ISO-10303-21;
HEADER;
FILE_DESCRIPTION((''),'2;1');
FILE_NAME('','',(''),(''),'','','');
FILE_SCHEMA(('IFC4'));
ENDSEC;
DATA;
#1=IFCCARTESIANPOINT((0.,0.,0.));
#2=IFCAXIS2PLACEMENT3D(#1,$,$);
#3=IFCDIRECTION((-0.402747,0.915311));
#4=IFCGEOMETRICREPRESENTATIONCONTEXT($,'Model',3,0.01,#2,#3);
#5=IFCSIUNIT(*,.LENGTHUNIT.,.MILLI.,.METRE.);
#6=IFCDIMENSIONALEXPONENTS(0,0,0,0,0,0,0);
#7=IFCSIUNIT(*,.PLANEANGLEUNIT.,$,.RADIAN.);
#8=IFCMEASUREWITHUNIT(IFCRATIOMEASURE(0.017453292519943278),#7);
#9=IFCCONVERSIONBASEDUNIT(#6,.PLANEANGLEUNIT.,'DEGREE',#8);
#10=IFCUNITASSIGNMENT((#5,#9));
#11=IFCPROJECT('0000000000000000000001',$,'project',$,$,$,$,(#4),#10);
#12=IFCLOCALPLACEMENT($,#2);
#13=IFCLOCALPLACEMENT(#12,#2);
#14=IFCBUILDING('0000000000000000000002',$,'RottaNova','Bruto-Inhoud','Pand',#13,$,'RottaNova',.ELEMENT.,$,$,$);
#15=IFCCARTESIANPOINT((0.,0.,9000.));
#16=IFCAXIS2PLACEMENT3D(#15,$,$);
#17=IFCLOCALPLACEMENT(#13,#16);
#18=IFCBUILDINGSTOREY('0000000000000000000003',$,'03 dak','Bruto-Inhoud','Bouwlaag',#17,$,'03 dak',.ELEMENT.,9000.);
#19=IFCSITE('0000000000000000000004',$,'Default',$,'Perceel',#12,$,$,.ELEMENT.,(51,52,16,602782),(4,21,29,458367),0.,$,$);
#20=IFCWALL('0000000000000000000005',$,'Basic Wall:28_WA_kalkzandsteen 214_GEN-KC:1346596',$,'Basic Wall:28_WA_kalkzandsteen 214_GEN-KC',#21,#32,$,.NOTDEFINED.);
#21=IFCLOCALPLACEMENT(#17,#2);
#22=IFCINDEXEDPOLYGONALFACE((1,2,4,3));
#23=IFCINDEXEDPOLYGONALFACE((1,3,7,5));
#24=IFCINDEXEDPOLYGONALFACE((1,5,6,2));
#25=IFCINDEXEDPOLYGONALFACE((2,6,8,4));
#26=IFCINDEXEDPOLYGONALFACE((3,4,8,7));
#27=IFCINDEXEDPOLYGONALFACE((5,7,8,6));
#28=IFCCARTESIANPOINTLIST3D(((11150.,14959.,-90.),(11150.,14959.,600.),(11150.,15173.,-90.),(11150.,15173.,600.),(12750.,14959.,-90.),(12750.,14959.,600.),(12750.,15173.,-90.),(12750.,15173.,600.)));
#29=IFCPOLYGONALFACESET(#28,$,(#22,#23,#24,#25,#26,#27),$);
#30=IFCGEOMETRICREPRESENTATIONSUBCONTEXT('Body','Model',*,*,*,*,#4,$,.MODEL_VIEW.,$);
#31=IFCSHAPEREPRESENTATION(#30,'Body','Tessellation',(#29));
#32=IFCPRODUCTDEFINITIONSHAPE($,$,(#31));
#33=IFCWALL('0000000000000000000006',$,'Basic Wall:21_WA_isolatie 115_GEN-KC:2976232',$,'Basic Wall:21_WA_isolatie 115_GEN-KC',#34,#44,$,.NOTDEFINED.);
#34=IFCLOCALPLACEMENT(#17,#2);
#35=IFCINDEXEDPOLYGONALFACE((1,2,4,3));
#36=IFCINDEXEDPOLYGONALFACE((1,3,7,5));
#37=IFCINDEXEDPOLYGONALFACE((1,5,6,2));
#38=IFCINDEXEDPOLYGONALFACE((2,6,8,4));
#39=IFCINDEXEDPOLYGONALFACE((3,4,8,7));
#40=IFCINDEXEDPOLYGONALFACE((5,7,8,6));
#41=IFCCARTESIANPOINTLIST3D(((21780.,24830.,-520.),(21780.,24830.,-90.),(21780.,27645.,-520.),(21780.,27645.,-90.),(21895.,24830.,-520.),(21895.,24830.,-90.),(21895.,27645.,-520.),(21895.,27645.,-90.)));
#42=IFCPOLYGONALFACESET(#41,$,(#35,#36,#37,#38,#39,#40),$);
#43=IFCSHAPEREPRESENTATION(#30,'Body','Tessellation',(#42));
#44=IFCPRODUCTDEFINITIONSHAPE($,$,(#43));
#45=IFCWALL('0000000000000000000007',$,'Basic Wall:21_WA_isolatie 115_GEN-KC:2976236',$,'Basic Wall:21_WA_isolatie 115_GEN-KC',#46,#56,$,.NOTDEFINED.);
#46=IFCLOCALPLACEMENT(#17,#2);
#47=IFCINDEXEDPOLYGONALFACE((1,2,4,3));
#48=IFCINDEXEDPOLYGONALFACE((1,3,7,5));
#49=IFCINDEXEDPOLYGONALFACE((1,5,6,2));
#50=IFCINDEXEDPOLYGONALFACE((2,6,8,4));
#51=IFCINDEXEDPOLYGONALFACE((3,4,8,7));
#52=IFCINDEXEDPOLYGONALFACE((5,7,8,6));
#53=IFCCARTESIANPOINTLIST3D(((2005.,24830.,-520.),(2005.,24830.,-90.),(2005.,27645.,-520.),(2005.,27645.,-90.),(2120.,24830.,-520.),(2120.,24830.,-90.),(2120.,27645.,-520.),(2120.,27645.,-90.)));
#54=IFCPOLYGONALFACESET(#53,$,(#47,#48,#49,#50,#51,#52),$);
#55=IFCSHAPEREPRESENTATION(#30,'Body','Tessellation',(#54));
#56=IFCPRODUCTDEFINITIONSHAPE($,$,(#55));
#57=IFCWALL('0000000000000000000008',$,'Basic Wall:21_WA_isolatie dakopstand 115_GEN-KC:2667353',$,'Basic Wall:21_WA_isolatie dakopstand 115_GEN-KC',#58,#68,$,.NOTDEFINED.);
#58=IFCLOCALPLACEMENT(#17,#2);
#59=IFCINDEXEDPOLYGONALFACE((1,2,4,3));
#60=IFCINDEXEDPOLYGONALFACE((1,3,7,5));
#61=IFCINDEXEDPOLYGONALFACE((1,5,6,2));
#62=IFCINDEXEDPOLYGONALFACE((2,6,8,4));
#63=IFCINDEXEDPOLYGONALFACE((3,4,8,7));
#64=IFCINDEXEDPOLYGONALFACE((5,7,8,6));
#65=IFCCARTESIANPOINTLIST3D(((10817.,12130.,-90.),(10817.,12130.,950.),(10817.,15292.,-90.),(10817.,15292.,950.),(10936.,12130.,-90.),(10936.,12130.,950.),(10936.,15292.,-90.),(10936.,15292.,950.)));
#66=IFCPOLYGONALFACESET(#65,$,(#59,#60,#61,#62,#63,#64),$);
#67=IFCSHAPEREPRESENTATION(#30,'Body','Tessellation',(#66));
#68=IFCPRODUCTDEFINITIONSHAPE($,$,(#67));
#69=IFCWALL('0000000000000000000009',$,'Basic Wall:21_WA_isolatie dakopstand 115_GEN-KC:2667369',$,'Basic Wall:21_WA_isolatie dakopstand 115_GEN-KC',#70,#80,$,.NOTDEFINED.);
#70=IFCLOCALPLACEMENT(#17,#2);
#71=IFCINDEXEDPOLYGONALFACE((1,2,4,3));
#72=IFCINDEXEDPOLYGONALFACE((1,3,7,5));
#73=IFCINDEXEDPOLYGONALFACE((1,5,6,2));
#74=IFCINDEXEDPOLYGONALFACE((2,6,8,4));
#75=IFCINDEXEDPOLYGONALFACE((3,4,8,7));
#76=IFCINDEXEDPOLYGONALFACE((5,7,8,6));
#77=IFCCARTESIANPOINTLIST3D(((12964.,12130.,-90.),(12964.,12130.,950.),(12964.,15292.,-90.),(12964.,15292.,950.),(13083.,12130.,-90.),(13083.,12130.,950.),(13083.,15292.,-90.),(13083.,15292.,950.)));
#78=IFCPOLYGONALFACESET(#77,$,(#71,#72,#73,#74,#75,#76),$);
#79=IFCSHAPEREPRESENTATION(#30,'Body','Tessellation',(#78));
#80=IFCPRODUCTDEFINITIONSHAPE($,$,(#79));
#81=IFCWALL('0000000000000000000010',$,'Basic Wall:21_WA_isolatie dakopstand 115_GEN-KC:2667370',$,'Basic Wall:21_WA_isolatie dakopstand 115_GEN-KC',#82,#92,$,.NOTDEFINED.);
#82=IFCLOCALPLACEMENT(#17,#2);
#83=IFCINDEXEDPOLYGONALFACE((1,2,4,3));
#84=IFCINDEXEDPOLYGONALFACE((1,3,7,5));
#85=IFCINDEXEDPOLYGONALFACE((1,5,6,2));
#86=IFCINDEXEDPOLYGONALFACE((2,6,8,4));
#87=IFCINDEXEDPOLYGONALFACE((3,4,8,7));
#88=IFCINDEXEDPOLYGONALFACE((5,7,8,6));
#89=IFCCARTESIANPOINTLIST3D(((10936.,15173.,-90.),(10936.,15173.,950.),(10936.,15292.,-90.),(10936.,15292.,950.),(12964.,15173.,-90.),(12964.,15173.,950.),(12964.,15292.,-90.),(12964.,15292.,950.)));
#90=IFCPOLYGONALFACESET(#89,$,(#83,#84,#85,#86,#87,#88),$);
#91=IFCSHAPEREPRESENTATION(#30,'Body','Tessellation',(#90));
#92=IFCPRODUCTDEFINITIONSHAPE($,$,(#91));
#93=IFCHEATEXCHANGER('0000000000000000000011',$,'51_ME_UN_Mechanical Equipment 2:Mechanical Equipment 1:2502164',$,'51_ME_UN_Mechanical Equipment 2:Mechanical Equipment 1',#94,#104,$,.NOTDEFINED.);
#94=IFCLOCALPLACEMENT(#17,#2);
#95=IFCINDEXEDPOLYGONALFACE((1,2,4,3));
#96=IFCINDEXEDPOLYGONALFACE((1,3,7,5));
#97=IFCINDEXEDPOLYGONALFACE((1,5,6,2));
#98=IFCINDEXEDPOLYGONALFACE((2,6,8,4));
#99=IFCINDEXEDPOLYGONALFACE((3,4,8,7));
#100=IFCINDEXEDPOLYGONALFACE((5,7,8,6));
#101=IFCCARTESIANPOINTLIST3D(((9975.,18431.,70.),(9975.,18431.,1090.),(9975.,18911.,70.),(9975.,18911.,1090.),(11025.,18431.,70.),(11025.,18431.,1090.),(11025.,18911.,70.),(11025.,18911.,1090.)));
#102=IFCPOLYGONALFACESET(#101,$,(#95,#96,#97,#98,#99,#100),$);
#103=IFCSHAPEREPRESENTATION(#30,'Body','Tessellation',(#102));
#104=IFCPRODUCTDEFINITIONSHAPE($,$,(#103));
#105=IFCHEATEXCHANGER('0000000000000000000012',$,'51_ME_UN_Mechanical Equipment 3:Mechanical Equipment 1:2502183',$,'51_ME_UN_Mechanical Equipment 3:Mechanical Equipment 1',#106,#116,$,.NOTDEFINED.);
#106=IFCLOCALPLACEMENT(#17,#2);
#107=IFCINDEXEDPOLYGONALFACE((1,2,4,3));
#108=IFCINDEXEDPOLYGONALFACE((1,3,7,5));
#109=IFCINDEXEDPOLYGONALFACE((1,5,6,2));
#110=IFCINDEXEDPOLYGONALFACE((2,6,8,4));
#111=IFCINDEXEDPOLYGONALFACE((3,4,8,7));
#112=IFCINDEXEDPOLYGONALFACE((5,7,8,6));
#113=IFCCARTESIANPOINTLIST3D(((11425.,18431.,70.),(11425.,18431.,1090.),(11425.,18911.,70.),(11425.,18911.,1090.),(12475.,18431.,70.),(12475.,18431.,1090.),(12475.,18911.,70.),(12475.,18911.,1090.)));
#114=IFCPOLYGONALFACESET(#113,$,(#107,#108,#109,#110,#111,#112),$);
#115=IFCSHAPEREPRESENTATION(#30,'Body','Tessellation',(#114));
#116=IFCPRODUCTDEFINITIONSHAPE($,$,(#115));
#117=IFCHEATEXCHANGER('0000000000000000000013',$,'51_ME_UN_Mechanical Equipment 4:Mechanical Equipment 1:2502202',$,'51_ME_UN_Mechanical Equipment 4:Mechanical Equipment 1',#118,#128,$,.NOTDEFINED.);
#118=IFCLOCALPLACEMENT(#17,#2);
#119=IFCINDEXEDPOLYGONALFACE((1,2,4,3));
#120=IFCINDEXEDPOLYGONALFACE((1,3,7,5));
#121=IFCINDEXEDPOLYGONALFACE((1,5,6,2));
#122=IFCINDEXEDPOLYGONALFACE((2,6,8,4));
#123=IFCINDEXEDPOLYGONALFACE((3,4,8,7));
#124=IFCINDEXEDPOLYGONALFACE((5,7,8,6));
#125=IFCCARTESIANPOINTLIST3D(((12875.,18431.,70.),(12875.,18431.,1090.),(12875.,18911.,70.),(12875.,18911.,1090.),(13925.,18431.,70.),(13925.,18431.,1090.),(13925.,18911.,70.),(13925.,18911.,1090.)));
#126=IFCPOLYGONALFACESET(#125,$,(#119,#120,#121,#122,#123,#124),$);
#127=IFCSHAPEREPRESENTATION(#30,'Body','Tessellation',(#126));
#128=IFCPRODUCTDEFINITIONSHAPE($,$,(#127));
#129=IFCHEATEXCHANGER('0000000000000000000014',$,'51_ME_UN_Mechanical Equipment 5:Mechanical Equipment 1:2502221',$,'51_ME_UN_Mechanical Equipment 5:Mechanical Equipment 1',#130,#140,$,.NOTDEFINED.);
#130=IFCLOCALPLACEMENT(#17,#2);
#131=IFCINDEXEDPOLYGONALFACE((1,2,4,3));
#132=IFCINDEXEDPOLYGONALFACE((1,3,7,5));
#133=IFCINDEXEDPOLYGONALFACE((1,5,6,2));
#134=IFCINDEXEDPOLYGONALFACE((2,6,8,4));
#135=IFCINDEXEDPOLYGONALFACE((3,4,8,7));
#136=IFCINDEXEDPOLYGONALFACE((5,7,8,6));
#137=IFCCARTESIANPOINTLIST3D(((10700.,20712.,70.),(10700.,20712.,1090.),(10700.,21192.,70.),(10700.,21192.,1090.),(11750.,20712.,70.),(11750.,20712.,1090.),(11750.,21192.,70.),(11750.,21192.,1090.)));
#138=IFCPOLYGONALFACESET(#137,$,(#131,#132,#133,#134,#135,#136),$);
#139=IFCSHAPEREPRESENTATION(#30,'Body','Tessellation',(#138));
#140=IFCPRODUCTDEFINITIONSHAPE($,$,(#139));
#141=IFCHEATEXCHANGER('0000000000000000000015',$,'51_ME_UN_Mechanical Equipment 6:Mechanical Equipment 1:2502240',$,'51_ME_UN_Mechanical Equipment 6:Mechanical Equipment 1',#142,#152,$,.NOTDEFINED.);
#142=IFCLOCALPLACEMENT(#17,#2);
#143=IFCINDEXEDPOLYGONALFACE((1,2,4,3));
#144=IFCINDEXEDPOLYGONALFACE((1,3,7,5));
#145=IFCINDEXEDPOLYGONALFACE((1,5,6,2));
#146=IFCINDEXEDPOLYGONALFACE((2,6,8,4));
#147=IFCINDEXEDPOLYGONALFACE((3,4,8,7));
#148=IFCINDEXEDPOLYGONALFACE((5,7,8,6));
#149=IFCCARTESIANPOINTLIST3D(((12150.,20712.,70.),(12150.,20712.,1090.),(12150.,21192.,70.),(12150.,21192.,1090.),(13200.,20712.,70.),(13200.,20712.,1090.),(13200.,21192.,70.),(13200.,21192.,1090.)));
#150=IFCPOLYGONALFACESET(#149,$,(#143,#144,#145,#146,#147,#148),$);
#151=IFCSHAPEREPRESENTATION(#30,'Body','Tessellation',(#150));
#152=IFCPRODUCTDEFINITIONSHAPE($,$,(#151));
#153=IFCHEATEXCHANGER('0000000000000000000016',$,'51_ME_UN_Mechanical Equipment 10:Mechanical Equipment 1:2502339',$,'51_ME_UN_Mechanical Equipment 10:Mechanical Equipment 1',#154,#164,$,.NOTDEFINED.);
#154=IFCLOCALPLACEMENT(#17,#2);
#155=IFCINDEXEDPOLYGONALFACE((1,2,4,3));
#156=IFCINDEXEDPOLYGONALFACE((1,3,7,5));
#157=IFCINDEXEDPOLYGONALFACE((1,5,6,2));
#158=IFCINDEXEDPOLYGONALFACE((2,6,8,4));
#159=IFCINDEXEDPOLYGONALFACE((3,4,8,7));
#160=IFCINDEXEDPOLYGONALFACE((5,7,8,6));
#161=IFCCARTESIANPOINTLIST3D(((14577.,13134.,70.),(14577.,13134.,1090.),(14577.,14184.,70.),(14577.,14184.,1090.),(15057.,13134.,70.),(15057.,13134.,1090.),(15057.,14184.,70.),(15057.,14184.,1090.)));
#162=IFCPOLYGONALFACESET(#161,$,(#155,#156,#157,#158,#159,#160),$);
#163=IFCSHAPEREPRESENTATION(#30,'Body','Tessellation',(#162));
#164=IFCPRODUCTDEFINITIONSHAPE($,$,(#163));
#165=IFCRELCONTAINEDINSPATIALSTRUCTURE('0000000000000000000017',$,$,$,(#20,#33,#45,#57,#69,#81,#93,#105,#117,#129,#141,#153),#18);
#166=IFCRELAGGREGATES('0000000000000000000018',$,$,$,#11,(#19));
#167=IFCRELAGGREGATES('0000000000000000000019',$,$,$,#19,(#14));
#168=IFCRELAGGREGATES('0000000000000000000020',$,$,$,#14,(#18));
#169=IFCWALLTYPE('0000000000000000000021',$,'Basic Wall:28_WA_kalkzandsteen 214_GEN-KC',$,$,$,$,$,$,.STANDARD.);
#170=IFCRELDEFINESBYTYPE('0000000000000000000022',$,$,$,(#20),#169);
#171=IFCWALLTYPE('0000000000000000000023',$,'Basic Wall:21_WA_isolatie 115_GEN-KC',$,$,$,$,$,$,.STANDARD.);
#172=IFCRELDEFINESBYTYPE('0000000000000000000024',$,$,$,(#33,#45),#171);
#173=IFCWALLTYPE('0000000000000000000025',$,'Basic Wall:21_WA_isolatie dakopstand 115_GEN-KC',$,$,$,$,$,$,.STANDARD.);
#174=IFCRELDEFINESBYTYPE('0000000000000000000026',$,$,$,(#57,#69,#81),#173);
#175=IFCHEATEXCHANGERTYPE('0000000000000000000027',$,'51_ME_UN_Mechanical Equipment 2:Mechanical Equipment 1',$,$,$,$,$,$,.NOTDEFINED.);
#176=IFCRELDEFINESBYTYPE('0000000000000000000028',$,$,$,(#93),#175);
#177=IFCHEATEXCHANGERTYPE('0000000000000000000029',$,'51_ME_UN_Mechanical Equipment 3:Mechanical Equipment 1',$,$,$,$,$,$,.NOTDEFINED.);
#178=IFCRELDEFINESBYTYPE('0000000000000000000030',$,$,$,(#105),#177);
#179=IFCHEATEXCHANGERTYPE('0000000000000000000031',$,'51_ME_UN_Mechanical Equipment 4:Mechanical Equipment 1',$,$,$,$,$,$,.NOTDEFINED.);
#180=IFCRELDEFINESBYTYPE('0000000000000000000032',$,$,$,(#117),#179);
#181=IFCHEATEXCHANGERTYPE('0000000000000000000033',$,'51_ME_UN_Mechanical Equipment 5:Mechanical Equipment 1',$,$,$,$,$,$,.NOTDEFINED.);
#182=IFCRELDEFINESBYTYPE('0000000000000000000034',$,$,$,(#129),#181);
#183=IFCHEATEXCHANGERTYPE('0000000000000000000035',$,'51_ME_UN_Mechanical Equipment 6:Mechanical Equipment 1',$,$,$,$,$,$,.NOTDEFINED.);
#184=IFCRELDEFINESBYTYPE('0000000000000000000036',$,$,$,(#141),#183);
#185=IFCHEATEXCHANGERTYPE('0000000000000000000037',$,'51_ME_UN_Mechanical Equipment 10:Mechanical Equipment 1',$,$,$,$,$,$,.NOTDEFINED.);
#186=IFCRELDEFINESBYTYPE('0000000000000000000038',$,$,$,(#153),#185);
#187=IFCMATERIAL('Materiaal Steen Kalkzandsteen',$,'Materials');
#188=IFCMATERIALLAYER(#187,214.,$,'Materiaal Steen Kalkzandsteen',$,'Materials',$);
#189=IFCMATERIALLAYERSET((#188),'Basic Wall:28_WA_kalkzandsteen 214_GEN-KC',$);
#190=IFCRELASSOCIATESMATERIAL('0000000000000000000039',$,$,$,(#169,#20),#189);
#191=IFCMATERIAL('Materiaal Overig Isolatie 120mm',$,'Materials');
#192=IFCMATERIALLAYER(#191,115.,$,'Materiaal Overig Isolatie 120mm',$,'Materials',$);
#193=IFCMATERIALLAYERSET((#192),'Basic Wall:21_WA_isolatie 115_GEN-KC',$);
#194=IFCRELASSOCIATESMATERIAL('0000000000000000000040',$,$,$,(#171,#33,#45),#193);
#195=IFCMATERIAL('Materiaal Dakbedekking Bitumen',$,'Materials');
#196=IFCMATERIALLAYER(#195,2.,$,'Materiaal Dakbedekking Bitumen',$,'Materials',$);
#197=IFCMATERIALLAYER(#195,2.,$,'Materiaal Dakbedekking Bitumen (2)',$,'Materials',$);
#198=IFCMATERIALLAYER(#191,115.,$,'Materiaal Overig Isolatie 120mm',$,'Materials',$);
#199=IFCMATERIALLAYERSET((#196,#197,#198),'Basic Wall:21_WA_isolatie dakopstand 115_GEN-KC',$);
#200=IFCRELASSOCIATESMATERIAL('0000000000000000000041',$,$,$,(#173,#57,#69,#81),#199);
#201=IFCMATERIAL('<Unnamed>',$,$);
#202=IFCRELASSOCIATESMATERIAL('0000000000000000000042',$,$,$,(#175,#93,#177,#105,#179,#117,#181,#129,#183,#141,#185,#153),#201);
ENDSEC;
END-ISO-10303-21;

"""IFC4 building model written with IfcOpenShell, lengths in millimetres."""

from ifc_helpers import new_model, entity, si_unit, converted_unit, direction, frame, frame_2d, origin, place, context, subcontext, project, spatial, rectangle, extrude, source, transform, mapped, material, layer, layer_set, type_object, type_shapes, element, save


model = new_model("IFC4")

# Units and contexts
model_context = context("Model", 3, precision=0.01, world=origin(), true_north=direction((-0.402747, 0.915311)))
body_context = subcontext(model_context, "Body", "Model", "MODEL_VIEW")
ifc_project = project(units=[si_unit("LENGTHUNIT", "METRE", prefix="MILLI"), converted_unit("PLANEANGLEUNIT", "DEGREE", entity("IfcRatioMeasure", 0.017453292519943278), si_unit("PLANEANGLEUNIT", "RADIAN"), dimensions=[0, 0, 0, 0, 0, 0, 0])], contexts=[model_context])

# Site, building, storey
site_placement = place(None, origin())
site = spatial("IfcSite", under=ifc_project, at=site_placement, Name="Default", ObjectType="Perceel", CompositionType="ELEMENT", RefLatitude=(51, 52, 16, 602782), RefLongitude=(4, 21, 29, 458367), RefElevation=0.0)
building_placement = place(site_placement, origin())
building = spatial("IfcBuilding", under=site, at=building_placement, Name="RottaNova", Description="Bruto-Inhoud", ObjectType="Pand", LongName="RottaNova", CompositionType="ELEMENT")
storey_placement = place(building_placement, frame((0.0, 0.0, 9000.0)))
storey = spatial("IfcBuildingStorey", under=building, at=storey_placement, Name="03 dak", Description="Bruto-Inhoud", ObjectType="Bouwlaag", LongName="03 dak", CompositionType="ELEMENT", Elevation=9000.0)

# Wall
ifc_material_1 = material(Name="Materiaal Steen Kalkzandsteen", Category="Materials")
ifc_layer_1 = layer(ifc_material_1, 214.0, Name="Materiaal Steen Kalkzandsteen", Category="Materials")
ifc_layer_set_1 = layer_set([ifc_layer_1], Name="Basic Wall:28_WA_kalkzandsteen 214_GEN-KC")
wall_type_1 = type_object("IfcWallType", Name="Basic Wall:28_WA_kalkzandsteen 214_GEN-KC", PredefinedType="STANDARD", material=ifc_layer_set_1)
wall_1_placement = place(storey_placement, frame((11150.0, 15066.0, -90.0)))
element("IfcWall", 1, at=wall_1_placement, inside=storey, type_object=wall_type_1, material=ifc_layer_set_1, Name="Basic Wall:28_WA_kalkzandsteen 214_GEN-KC:1346596", ObjectType="Basic Wall:28_WA_kalkzandsteen 214_GEN-KC", PredefinedType="NOTDEFINED", context=body_context, shape_type="SweptSolid", body=[
    extrude(rectangle(XDim=1600.0, YDim=214.0, at=frame_2d((800.0, 0.0), x_axis=(-1.0, 0.0))), origin(), (0.0, 0.0, 1.0), 690.0),
])

# Shared definitions
ifc_material_2 = material(Name="Materiaal Overig Isolatie 120mm", Category="Materials")
ifc_layer_2 = layer(ifc_material_2, 115.0, Name="Materiaal Overig Isolatie 120mm", Category="Materials")
ifc_layer_set_2 = layer_set([ifc_layer_2], Name="Basic Wall:21_WA_isolatie 115_GEN-KC")
wall_type_2 = type_object("IfcWallType", Name="Basic Wall:21_WA_isolatie 115_GEN-KC", PredefinedType="STANDARD", material=ifc_layer_set_2)

# Wall
wall_2_placement = place(storey_placement, frame((21837.5, 24830.0, -520.0), z_axis=(0.0, 0.0, 1.0), x_axis=(0.0, 1.0, 0.0)))
element("IfcWall", 2, at=wall_2_placement, inside=storey, type_object=wall_type_2, material=ifc_layer_set_2, Name="Basic Wall:21_WA_isolatie 115_GEN-KC:2976232", ObjectType="Basic Wall:21_WA_isolatie 115_GEN-KC", PredefinedType="NOTDEFINED", context=body_context, shape_type="SweptSolid", body=[
    extrude(rectangle(XDim=2815.0, YDim=115.0, at=frame_2d((1407.5, 0.0), x_axis=(-1.0, 0.0))), origin(), (0.0, 0.0, 1.0), 430.0),
])

# Walls
wall_3_placement = place(storey_placement, frame((2062.5, 24830.0, -520.0), z_axis=(0.0, 0.0, 1.0), x_axis=(0.0, 1.0, 0.0)))
element("IfcWall", 3, at=wall_3_placement, inside=storey, type_object=wall_type_2, material=ifc_layer_set_2, Name="Basic Wall:21_WA_isolatie 115_GEN-KC:2976236", ObjectType="Basic Wall:21_WA_isolatie 115_GEN-KC", PredefinedType="NOTDEFINED", context=body_context, shape_type="SweptSolid", body=[
    extrude(rectangle(XDim=2815.0, YDim=115.0, at=frame_2d((1407.5, 0.0), x_axis=(-1.0, 0.0))), origin(), (0.0, 0.0, 1.0), 430.0),
])
ifc_material_3 = material(Name="Materiaal Dakbedekking Bitumen", Category="Materials")
ifc_layer_3 = layer(ifc_material_3, 2.0, Name="Materiaal Dakbedekking Bitumen", Category="Materials")
ifc_layer_4 = layer(ifc_material_3, 2.0, Name="Materiaal Dakbedekking Bitumen (2)", Category="Materials")
ifc_layer_5 = layer(ifc_material_2, 115.0, Name="Materiaal Overig Isolatie 120mm", Category="Materials")
ifc_layer_set_3 = layer_set([ifc_layer_3, ifc_layer_4, ifc_layer_5], Name="Basic Wall:21_WA_isolatie dakopstand 115_GEN-KC")
wall_type_3 = type_object("IfcWallType", Name="Basic Wall:21_WA_isolatie dakopstand 115_GEN-KC", PredefinedType="STANDARD", material=ifc_layer_set_3)
wall_4_placement = place(storey_placement, frame((10876.5, 15292.0, -90.0), z_axis=(0.0, 0.0, 1.0), x_axis=(0.0, -1.0, 0.0)))
element("IfcWall", 4, at=wall_4_placement, inside=storey, type_object=wall_type_3, material=ifc_layer_set_3, Name="Basic Wall:21_WA_isolatie dakopstand 115_GEN-KC:2667353", ObjectType="Basic Wall:21_WA_isolatie dakopstand 115_GEN-KC", PredefinedType="NOTDEFINED", context=body_context, shape_type="SweptSolid", body=[
    extrude(rectangle(XDim=3162.0, YDim=119.0, at=frame_2d((1581.0, 0.0), x_axis=(-1.0, 0.0))), origin(), (0.0, 0.0, 1.0), 1040.0),
])
wall_5_placement = place(storey_placement, frame((13023.5, 15292.0, -90.0), z_axis=(0.0, 0.0, 1.0), x_axis=(0.0, -1.0, 0.0)))
element("IfcWall", 5, at=wall_5_placement, inside=storey, type_object=wall_type_3, material=ifc_layer_set_3, Name="Basic Wall:21_WA_isolatie dakopstand 115_GEN-KC:2667369", ObjectType="Basic Wall:21_WA_isolatie dakopstand 115_GEN-KC", PredefinedType="NOTDEFINED", context=body_context, shape_type="SweptSolid", body=[
    extrude(rectangle(XDim=3162.0, YDim=119.0, at=frame_2d((1581.0, 0.0), x_axis=(-1.0, 0.0))), origin(), (0.0, 0.0, 1.0), 1040.0),
])
wall_6_placement = place(storey_placement, frame((10936.0, 15232.5, -90.0)))
element("IfcWall", 6, at=wall_6_placement, inside=storey, type_object=wall_type_3, material=ifc_layer_set_3, Name="Basic Wall:21_WA_isolatie dakopstand 115_GEN-KC:2667370", ObjectType="Basic Wall:21_WA_isolatie dakopstand 115_GEN-KC", PredefinedType="NOTDEFINED", context=body_context, shape_type="SweptSolid", body=[
    extrude(rectangle(XDim=2028.0, YDim=119.0, at=frame_2d((1014.0, 0.0), x_axis=(-1.0, 0.0))), origin(), (0.0, 0.0, 1.0), 1040.0),
])

# Heat exchangers
ifc_material_4 = material(Name="<Unnamed>")
heat_exchanger_type_1 = type_object("IfcHeatExchangerType", Name="51_ME_UN_Mechanical Equipment 2:Mechanical Equipment 1", PredefinedType="NOTDEFINED", material=ifc_material_4)
shared_shape_1 = source(origin(), body_context, "Body", "SweptSolid", [
    extrude(rectangle(XDim=1050.0, YDim=480.0, at=frame_2d((0.0, 0.0), x_axis=(1.0, 0.0))), frame((525.0, 240.0, 0.0), z_axis=(0.0, 0.0, 1.0), x_axis=(-1.0, 0.0, 0.0)), (0.0, 0.0, 1.0), 1020.0),
])
type_shapes(heat_exchanger_type_1, [shared_shape_1])
heat_exchanger_1_placement = place(storey_placement, frame((9975.0, 18431.0, 70.0)))
element("IfcHeatExchanger", 7, at=heat_exchanger_1_placement, inside=storey, type_object=heat_exchanger_type_1, material=ifc_material_4, Name="51_ME_UN_Mechanical Equipment 2:Mechanical Equipment 1:2502164", ObjectType="51_ME_UN_Mechanical Equipment 2:Mechanical Equipment 1", PredefinedType="NOTDEFINED", context=body_context, shape_type="MappedRepresentation", body=[
    mapped(shared_shape_1, transform((0.0, 0.0, 0.0), scale=1.0)),
])
heat_exchanger_type_2 = type_object("IfcHeatExchangerType", Name="51_ME_UN_Mechanical Equipment 3:Mechanical Equipment 1", PredefinedType="NOTDEFINED", material=ifc_material_4)
shared_shape_2 = source(origin(), body_context, "Body", "SweptSolid", [
    extrude(rectangle(XDim=1050.0, YDim=480.0, at=frame_2d((0.0, 0.0), x_axis=(1.0, 0.0))), frame((525.0, 240.0, 0.0), z_axis=(0.0, 0.0, 1.0), x_axis=(-1.0, 0.0, 0.0)), (0.0, 0.0, 1.0), 1020.0),
])
type_shapes(heat_exchanger_type_2, [shared_shape_2])
heat_exchanger_2_placement = place(storey_placement, frame((11425.0, 18431.0, 70.0)))
element("IfcHeatExchanger", 8, at=heat_exchanger_2_placement, inside=storey, type_object=heat_exchanger_type_2, material=ifc_material_4, Name="51_ME_UN_Mechanical Equipment 3:Mechanical Equipment 1:2502183", ObjectType="51_ME_UN_Mechanical Equipment 3:Mechanical Equipment 1", PredefinedType="NOTDEFINED", context=body_context, shape_type="MappedRepresentation", body=[
    mapped(shared_shape_2, transform((0.0, 0.0, 0.0), scale=1.0)),
])
heat_exchanger_type_3 = type_object("IfcHeatExchangerType", Name="51_ME_UN_Mechanical Equipment 4:Mechanical Equipment 1", PredefinedType="NOTDEFINED", material=ifc_material_4)
shared_shape_3 = source(origin(), body_context, "Body", "SweptSolid", [
    extrude(rectangle(XDim=1050.0, YDim=480.0, at=frame_2d((0.0, 0.0), x_axis=(1.0, 0.0))), frame((525.0, 240.0, 0.0), z_axis=(0.0, 0.0, 1.0), x_axis=(-1.0, 0.0, 0.0)), (0.0, 0.0, 1.0), 1020.0),
])
type_shapes(heat_exchanger_type_3, [shared_shape_3])
heat_exchanger_3_placement = place(storey_placement, frame((12875.0, 18431.0, 70.0)))
element("IfcHeatExchanger", 9, at=heat_exchanger_3_placement, inside=storey, type_object=heat_exchanger_type_3, material=ifc_material_4, Name="51_ME_UN_Mechanical Equipment 4:Mechanical Equipment 1:2502202", ObjectType="51_ME_UN_Mechanical Equipment 4:Mechanical Equipment 1", PredefinedType="NOTDEFINED", context=body_context, shape_type="MappedRepresentation", body=[
    mapped(shared_shape_3, transform((0.0, 0.0, 0.0), scale=1.0)),
])
heat_exchanger_type_4 = type_object("IfcHeatExchangerType", Name="51_ME_UN_Mechanical Equipment 5:Mechanical Equipment 1", PredefinedType="NOTDEFINED", material=ifc_material_4)
shared_shape_4 = source(origin(), body_context, "Body", "SweptSolid", [
    extrude(rectangle(XDim=1050.0, YDim=480.0, at=frame_2d((0.0, 0.0), x_axis=(1.0, 0.0))), frame((525.0, 240.0, 0.0), z_axis=(0.0, 0.0, 1.0), x_axis=(-1.0, 0.0, 0.0)), (0.0, 0.0, 1.0), 1020.0),
])
type_shapes(heat_exchanger_type_4, [shared_shape_4])
heat_exchanger_4_placement = place(storey_placement, frame((10700.0, 20712.0, 70.0)))
element("IfcHeatExchanger", 10, at=heat_exchanger_4_placement, inside=storey, type_object=heat_exchanger_type_4, material=ifc_material_4, Name="51_ME_UN_Mechanical Equipment 5:Mechanical Equipment 1:2502221", ObjectType="51_ME_UN_Mechanical Equipment 5:Mechanical Equipment 1", PredefinedType="NOTDEFINED", context=body_context, shape_type="MappedRepresentation", body=[
    mapped(shared_shape_4, transform((0.0, 0.0, 0.0), scale=1.0)),
])
heat_exchanger_type_5 = type_object("IfcHeatExchangerType", Name="51_ME_UN_Mechanical Equipment 6:Mechanical Equipment 1", PredefinedType="NOTDEFINED", material=ifc_material_4)
shared_shape_5 = source(origin(), body_context, "Body", "SweptSolid", [
    extrude(rectangle(XDim=1050.0, YDim=480.0, at=frame_2d((0.0, 0.0), x_axis=(1.0, 0.0))), frame((525.0, 240.0, 0.0), z_axis=(0.0, 0.0, 1.0), x_axis=(-1.0, 0.0, 0.0)), (0.0, 0.0, 1.0), 1020.0),
])
type_shapes(heat_exchanger_type_5, [shared_shape_5])
heat_exchanger_5_placement = place(storey_placement, frame((12150.0, 20712.0, 70.0)))
element("IfcHeatExchanger", 11, at=heat_exchanger_5_placement, inside=storey, type_object=heat_exchanger_type_5, material=ifc_material_4, Name="51_ME_UN_Mechanical Equipment 6:Mechanical Equipment 1:2502240", ObjectType="51_ME_UN_Mechanical Equipment 6:Mechanical Equipment 1", PredefinedType="NOTDEFINED", context=body_context, shape_type="MappedRepresentation", body=[
    mapped(shared_shape_5, transform((0.0, 0.0, 0.0), scale=1.0)),
])
heat_exchanger_type_6 = type_object("IfcHeatExchangerType", Name="51_ME_UN_Mechanical Equipment 10:Mechanical Equipment 1", PredefinedType="NOTDEFINED", material=ifc_material_4)
shared_shape_6 = source(origin(), body_context, "Body", "SweptSolid", [
    extrude(rectangle(XDim=1050.0, YDim=480.0, at=frame_2d((0.0, 0.0), x_axis=(1.0, 0.0))), frame((525.0, 240.0, 0.0), z_axis=(0.0, 0.0, 1.0), x_axis=(-1.0, 0.0, 0.0)), (0.0, 0.0, 1.0), 1020.0),
])
type_shapes(heat_exchanger_type_6, [shared_shape_6])
heat_exchanger_6_placement = place(storey_placement, frame((15057.0, 13134.0, 70.0), z_axis=(0.0, 0.0, 1.0), x_axis=(0.0, 1.0, 0.0)))
element("IfcHeatExchanger", 12, at=heat_exchanger_6_placement, inside=storey, type_object=heat_exchanger_type_6, material=ifc_material_4, Name="51_ME_UN_Mechanical Equipment 10:Mechanical Equipment 1:2502339", ObjectType="51_ME_UN_Mechanical Equipment 10:Mechanical Equipment 1", PredefinedType="NOTDEFINED", context=body_context, shape_type="MappedRepresentation", body=[
    mapped(shared_shape_6, transform((0.0, 0.0, 0.0), scale=1.0)),
])

save(model, "model.ifc")
